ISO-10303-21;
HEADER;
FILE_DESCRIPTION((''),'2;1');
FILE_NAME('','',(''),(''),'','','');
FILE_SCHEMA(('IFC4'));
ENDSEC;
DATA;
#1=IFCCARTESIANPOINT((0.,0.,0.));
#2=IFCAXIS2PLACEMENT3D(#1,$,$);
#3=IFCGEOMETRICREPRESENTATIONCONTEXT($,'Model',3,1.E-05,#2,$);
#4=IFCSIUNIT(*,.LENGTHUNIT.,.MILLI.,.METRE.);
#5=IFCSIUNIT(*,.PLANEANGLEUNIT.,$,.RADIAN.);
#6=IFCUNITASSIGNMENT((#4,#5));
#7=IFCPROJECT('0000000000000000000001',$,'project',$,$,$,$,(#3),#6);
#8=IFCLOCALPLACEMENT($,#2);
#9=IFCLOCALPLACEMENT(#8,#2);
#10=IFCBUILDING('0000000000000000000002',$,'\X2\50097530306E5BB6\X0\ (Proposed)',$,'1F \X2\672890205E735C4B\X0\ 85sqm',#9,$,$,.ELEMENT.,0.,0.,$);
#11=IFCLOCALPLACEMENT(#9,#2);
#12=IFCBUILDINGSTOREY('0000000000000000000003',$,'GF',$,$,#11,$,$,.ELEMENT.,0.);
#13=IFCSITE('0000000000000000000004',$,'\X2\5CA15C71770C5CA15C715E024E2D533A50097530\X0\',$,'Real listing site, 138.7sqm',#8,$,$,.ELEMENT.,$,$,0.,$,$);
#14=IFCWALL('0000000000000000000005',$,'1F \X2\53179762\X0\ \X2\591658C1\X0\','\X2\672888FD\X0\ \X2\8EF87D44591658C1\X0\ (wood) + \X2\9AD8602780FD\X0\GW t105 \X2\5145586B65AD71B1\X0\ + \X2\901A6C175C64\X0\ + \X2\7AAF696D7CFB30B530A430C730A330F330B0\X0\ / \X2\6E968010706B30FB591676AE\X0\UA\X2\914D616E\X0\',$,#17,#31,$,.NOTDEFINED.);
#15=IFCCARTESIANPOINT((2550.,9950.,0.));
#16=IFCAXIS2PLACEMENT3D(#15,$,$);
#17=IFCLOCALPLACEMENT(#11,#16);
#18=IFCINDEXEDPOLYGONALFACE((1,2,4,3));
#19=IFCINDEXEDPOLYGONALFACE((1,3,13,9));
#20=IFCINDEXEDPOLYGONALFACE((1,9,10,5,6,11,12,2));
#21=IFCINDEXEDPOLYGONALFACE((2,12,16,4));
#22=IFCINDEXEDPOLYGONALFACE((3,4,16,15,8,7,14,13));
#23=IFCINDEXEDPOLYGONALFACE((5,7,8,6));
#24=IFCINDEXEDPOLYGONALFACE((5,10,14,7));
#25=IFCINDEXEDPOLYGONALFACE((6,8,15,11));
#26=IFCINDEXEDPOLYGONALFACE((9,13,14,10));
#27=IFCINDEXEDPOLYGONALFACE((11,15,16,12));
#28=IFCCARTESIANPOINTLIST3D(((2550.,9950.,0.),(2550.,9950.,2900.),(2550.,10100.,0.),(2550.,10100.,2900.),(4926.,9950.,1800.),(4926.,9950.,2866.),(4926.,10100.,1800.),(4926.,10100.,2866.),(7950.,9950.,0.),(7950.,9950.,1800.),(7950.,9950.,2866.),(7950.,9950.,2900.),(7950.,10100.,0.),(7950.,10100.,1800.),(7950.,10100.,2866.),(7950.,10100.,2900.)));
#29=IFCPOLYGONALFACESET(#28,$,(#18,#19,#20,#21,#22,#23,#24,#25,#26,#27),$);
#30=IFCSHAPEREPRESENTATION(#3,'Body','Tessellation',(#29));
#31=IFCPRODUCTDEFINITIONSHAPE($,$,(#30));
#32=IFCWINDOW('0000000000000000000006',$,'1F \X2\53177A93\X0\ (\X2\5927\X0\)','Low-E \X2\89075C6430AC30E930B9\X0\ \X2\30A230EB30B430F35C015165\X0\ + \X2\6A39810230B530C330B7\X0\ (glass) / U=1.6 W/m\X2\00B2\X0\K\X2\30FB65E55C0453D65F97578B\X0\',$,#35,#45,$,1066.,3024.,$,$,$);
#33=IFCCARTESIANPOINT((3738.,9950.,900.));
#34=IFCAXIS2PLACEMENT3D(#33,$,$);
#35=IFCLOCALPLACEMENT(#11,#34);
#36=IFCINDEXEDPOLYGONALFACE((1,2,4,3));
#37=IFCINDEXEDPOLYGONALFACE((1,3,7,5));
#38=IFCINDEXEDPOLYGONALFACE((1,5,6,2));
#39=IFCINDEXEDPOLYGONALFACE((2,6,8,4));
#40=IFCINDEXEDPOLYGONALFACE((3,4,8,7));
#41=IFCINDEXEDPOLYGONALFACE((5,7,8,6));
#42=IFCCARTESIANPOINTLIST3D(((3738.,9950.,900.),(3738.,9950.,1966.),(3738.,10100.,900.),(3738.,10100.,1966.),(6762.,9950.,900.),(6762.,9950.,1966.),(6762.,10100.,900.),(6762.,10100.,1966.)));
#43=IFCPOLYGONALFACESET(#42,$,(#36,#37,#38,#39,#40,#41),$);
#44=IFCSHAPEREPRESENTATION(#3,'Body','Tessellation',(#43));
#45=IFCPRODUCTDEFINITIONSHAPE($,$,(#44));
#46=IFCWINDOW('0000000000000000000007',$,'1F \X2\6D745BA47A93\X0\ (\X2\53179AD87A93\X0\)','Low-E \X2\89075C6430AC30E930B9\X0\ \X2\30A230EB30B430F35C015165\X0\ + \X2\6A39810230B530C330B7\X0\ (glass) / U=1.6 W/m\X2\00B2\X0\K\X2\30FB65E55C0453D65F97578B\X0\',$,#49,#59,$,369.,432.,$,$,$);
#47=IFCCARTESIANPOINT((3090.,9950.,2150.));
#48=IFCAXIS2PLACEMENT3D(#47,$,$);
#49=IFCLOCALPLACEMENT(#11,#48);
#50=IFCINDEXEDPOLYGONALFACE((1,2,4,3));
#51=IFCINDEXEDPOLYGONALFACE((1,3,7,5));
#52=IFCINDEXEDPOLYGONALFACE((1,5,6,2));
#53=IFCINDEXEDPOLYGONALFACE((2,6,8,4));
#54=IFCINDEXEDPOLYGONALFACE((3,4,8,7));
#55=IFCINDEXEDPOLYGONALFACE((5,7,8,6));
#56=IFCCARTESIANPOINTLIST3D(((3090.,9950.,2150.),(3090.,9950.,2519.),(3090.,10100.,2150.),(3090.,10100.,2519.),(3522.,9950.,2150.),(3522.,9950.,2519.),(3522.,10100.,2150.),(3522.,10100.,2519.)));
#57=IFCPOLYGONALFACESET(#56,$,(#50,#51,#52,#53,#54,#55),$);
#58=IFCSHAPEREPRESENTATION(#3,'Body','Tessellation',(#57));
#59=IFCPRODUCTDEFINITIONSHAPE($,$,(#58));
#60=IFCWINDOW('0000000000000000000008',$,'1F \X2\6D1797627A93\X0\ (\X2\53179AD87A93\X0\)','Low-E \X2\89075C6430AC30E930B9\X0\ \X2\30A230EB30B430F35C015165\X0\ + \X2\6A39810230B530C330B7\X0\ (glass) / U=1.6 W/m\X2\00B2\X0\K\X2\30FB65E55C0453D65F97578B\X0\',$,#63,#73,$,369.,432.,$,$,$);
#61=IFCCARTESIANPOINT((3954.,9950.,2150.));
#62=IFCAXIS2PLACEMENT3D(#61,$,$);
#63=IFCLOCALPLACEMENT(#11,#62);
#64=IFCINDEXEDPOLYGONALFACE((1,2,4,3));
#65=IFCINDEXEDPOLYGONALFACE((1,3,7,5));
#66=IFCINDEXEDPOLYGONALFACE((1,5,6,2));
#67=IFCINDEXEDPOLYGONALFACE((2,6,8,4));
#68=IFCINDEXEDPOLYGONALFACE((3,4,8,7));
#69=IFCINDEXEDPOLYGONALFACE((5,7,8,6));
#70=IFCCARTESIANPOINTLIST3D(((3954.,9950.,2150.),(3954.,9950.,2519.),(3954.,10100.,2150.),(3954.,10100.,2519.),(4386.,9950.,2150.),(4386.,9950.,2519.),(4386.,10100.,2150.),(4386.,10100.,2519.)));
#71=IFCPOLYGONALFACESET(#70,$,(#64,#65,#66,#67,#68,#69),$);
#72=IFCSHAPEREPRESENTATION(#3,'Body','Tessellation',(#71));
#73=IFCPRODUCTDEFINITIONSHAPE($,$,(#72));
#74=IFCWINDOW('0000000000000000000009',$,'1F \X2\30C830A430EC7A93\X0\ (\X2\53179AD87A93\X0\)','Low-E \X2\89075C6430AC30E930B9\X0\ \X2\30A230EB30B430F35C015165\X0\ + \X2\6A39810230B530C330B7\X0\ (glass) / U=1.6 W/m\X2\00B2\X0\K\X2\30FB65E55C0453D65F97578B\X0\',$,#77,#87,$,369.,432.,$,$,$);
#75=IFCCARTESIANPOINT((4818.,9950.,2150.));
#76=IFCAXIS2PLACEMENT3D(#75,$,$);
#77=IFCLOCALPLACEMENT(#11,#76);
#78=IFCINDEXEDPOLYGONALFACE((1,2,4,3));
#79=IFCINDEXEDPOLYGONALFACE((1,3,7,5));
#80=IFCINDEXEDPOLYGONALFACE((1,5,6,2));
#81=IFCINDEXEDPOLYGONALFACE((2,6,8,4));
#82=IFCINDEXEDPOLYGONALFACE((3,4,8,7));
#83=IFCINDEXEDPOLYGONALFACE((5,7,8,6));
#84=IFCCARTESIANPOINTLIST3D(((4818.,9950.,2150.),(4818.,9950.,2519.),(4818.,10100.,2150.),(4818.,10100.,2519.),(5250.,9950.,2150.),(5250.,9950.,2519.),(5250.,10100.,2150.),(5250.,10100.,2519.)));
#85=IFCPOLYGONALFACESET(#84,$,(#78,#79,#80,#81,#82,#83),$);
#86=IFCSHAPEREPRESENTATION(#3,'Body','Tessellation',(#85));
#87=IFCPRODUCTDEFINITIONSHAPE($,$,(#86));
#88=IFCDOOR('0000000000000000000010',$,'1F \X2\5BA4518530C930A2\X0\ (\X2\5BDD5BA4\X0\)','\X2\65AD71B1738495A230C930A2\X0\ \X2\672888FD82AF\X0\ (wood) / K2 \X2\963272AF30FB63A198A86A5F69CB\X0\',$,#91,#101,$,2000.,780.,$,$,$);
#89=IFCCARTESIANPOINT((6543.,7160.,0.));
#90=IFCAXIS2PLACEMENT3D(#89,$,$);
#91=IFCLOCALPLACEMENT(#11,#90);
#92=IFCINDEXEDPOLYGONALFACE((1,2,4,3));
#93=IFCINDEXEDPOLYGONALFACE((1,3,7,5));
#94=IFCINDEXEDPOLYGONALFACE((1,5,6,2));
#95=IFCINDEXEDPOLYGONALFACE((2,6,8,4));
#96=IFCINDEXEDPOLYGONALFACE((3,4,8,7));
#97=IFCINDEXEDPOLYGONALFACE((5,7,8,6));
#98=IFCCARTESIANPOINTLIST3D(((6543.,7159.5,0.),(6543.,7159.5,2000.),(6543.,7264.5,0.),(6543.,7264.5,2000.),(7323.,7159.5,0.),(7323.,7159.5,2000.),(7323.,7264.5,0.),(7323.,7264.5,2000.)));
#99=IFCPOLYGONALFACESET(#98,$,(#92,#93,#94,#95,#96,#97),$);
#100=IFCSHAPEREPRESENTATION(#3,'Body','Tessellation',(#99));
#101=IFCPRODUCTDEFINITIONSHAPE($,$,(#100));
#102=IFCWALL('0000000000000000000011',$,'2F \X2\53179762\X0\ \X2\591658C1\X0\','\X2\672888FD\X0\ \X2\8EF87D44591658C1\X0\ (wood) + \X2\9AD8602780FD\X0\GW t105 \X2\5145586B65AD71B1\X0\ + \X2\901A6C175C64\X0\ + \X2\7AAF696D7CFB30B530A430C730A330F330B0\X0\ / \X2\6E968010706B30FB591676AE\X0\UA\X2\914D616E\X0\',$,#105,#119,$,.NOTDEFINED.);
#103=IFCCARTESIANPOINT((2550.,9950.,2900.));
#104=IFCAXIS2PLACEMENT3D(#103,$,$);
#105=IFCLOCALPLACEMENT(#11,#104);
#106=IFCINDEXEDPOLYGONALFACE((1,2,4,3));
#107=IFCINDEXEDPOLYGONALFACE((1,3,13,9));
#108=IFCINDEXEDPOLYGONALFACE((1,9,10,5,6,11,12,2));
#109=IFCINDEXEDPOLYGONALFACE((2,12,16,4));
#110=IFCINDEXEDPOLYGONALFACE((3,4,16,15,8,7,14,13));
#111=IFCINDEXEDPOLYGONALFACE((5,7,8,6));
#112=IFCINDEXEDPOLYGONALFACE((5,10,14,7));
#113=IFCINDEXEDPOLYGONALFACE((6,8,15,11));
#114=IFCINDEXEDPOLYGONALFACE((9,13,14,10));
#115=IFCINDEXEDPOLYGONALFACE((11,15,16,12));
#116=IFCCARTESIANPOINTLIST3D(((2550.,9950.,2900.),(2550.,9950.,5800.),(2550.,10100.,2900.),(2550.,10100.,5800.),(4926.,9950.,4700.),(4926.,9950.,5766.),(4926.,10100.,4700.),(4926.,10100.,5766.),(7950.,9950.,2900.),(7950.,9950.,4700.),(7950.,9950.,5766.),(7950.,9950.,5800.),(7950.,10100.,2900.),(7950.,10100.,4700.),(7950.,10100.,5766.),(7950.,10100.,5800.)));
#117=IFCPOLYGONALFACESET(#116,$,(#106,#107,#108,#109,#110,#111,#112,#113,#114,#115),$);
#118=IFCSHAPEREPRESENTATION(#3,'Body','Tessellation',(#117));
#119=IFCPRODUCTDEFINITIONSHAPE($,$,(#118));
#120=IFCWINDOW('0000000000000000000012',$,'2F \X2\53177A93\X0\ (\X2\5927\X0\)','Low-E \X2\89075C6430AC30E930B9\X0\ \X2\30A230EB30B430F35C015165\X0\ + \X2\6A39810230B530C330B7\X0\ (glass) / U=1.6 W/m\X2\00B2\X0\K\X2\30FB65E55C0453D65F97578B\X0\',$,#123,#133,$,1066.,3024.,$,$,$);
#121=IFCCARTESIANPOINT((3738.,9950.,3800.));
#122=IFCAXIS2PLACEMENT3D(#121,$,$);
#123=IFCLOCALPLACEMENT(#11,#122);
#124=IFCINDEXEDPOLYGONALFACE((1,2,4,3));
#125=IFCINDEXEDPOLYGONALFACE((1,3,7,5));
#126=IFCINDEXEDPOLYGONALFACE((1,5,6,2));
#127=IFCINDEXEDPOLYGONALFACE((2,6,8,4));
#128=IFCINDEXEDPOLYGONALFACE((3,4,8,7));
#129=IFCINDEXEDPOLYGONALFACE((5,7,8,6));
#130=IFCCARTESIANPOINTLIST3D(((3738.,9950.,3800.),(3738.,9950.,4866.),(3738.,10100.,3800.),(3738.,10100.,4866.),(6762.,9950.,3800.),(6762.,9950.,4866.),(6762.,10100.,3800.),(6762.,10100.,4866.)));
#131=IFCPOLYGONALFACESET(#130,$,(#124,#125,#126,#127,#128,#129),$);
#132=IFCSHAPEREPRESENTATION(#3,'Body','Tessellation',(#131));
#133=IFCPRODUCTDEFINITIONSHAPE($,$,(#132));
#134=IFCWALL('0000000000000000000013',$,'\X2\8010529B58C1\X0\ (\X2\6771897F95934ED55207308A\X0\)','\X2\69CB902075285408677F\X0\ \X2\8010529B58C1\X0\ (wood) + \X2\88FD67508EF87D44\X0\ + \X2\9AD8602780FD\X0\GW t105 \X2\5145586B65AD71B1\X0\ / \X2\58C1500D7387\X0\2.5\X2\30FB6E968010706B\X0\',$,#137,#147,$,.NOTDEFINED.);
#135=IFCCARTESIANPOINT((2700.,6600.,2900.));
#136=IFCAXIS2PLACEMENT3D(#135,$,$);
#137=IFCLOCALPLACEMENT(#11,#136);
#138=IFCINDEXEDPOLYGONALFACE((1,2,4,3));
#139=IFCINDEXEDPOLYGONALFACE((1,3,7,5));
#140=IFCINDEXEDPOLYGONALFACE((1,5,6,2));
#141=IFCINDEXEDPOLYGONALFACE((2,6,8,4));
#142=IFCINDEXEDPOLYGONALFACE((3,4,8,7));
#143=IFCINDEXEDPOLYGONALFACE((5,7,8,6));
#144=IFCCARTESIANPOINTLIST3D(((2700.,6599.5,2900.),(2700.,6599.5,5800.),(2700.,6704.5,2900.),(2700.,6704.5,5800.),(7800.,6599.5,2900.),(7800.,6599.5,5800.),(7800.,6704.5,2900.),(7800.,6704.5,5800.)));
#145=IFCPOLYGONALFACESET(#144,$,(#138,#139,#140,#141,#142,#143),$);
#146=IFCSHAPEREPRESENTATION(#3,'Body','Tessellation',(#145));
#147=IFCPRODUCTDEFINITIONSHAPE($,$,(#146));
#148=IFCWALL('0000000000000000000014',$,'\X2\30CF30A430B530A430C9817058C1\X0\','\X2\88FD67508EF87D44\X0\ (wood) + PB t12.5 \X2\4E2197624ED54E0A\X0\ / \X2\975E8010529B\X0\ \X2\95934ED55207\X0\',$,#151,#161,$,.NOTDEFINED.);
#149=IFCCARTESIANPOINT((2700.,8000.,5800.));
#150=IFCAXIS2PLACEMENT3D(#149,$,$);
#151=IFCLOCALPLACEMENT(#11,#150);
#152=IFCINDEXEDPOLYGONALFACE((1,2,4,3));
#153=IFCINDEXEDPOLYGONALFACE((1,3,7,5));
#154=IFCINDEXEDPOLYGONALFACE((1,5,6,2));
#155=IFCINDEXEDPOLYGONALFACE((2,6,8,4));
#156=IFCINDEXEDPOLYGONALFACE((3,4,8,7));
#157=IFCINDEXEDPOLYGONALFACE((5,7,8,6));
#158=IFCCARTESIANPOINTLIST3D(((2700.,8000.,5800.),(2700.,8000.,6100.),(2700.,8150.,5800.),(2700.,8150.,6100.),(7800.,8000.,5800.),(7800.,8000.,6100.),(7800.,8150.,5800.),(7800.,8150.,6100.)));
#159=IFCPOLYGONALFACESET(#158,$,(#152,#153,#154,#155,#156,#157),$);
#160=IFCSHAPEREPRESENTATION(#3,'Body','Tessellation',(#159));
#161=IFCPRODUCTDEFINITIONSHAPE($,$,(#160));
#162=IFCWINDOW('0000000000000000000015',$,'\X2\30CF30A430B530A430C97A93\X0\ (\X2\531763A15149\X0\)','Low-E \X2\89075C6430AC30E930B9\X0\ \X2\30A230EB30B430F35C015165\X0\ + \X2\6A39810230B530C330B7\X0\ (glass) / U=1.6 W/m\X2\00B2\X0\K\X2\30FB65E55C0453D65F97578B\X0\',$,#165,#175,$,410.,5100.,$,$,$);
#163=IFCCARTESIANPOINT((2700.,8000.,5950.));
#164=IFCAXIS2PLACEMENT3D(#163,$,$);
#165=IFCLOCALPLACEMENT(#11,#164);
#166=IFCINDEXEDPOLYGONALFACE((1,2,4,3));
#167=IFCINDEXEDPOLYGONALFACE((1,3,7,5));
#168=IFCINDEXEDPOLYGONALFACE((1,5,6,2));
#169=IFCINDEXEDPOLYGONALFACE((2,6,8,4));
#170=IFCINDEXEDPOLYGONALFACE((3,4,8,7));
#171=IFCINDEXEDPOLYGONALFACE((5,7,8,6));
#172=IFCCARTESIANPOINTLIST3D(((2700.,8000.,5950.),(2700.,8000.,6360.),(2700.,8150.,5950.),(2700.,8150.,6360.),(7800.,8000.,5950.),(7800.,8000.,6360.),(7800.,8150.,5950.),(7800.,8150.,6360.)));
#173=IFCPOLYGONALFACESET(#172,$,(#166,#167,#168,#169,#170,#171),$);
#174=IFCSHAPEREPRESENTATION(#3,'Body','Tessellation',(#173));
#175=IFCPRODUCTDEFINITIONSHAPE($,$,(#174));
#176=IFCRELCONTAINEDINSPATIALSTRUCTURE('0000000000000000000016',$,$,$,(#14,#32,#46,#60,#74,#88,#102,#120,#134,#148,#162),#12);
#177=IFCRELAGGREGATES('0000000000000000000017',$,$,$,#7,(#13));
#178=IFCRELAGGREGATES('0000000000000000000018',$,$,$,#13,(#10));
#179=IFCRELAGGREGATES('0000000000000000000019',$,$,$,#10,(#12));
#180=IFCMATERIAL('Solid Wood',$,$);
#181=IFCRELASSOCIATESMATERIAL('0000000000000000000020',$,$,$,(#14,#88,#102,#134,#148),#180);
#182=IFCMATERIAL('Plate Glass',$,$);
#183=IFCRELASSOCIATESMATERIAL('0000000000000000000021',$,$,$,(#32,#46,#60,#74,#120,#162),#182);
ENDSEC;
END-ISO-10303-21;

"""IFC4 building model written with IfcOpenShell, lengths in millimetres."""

from ifc_helpers import new_model, si_unit, frame, frame_2d, origin, place, context, project, spatial, rectangle, extrude, material, element, fill, save


model = new_model("IFC4")

# Units and contexts
model_context = context("Model", 3, precision=1e-05, world=origin())
ifc_project = project(units=[si_unit("LENGTHUNIT", "METRE", prefix="MILLI"), si_unit("PLANEANGLEUNIT", "RADIAN")], contexts=[model_context])

# Site, building, storey
site_placement = place(None, origin())
site = spatial("IfcSite", under=ifc_project, at=site_placement, Name="岡山県岡山市中区倉田", ObjectType="Real listing site, 138.7sqm", CompositionType="ELEMENT", RefElevation=0.0)
building_placement = place(site_placement, origin())
building = spatial("IfcBuilding", under=site, at=building_placement, Name="倉田の家 (Proposed)", ObjectType="1F 木造平屋 85sqm", CompositionType="ELEMENT", ElevationOfRefHeight=0.0, ElevationOfTerrain=0.0)
storey_placement = place(building_placement, origin())
storey = spatial("IfcBuildingStorey", under=building, at=storey_placement, Name="GF", CompositionType="ELEMENT", Elevation=0.0)

# Wall, openings, windows
ifc_material_1 = material(Name="Solid Wood")
wall_1_placement = place(storey_placement, frame((2550.0, 9950.0, 0.0)))
wall_1 = element("IfcWall", 1, at=wall_1_placement, inside=storey, material=ifc_material_1, Name="1F 北面 外壁", Description="木製 軸組外壁 (wood) + 高性能GW t105 充填断熱 + 通気層 + 窯業系サイディング / 準耐火・外皮UA配慮", PredefinedType="NOTDEFINED", context=model_context, shape_type="SweptSolid", body=[
    extrude(rectangle(XDim=5400.0, YDim=150.0, at=frame_2d((2700.0, 75.0))), frame((2550.0, 9950.0, 0.0)), (0.0, 0.0, 1.0), 2900.0),
])
opening_1_placement = place(storey_placement, frame((3738.0, 9950.0, 900.0)))
opening_1 = element("IfcOpeningElement", 2, at=opening_1_placement, cuts=wall_1, PredefinedType="NOTDEFINED", context=model_context, shape_type="SweptSolid", body=[
    extrude(rectangle(XDim=3024.0, YDim=150.0, at=frame_2d((1512.0, 75.0))), frame((3738.0, 9950.0, 900.0)), (0.0, 0.0, 1.0), 1066.0),
])
opening_2_placement = place(storey_placement, frame((3090.0, 9950.0, 2150.0)))
opening_2 = element("IfcOpeningElement", 3, at=opening_2_placement, cuts=wall_1, PredefinedType="NOTDEFINED", context=model_context, shape_type="SweptSolid", body=[
    extrude(rectangle(XDim=432.0, YDim=150.0, at=frame_2d((216.0, 75.0))), frame((3090.0, 9950.0, 2150.0)), (0.0, 0.0, 1.0), 369.0),
])
opening_3_placement = place(storey_placement, frame((3954.0, 9950.0, 2150.0)))
opening_3 = element("IfcOpeningElement", 4, at=opening_3_placement, cuts=wall_1, PredefinedType="NOTDEFINED", context=model_context, shape_type="SweptSolid", body=[
    extrude(rectangle(XDim=432.0, YDim=150.0, at=frame_2d((216.0, 75.0))), frame((3954.0, 9950.0, 2150.0)), (0.0, 0.0, 1.0), 369.0),
])
opening_4_placement = place(storey_placement, frame((4818.0, 9950.0, 2150.0)))
opening_4 = element("IfcOpeningElement", 5, at=opening_4_placement, cuts=wall_1, PredefinedType="NOTDEFINED", context=model_context, shape_type="SweptSolid", body=[
    extrude(rectangle(XDim=432.0, YDim=150.0, at=frame_2d((216.0, 75.0))), frame((4818.0, 9950.0, 2150.0)), (0.0, 0.0, 1.0), 369.0),
])
ifc_material_2 = material(Name="Plate Glass")
window_1_placement = place(storey_placement, frame((3738.0, 9950.0, 900.0)))
window_1 = element("IfcWindow", 6, at=window_1_placement, inside=storey, material=ifc_material_2, Name="1F 北窓 (大)", Description="Low-E 複層ガラス アルゴン封入 + 樹脂サッシ (glass) / U=1.6 W/m²K・日射取得型", OverallHeight=1066.0, OverallWidth=3024.0, context=model_context, shape_type="SweptSolid", body=[
    extrude(rectangle(XDim=3024.0, YDim=150.0, at=frame_2d((1512.0, 75.0))), frame((3738.0, 9950.0, 900.0)), (0.0, 0.0, 1.0), 1066.0),
])
fill(opening_1, window_1)
window_2_placement = place(storey_placement, frame((3090.0, 9950.0, 2150.0)))
window_2 = element("IfcWindow", 7, at=window_2_placement, inside=storey, material=ifc_material_2, Name="1F 浴室窓 (北高窓)", Description="Low-E 複層ガラス アルゴン封入 + 樹脂サッシ (glass) / U=1.6 W/m²K・日射取得型", OverallHeight=369.0, OverallWidth=432.0, context=model_context, shape_type="SweptSolid", body=[
    extrude(rectangle(XDim=432.0, YDim=150.0, at=frame_2d((216.0, 75.0))), frame((3090.0, 9950.0, 2150.0)), (0.0, 0.0, 1.0), 369.0),
])
fill(opening_2, window_2)
window_3_placement = place(storey_placement, frame((3954.0, 9950.0, 2150.0)))
window_3 = element("IfcWindow", 8, at=window_3_placement, inside=storey, material=ifc_material_2, Name="1F 洗面窓 (北高窓)", Description="Low-E 複層ガラス アルゴン封入 + 樹脂サッシ (glass) / U=1.6 W/m²K・日射取得型", OverallHeight=369.0, OverallWidth=432.0, context=model_context, shape_type="SweptSolid", body=[
    extrude(rectangle(XDim=432.0, YDim=150.0, at=frame_2d((216.0, 75.0))), frame((3954.0, 9950.0, 2150.0)), (0.0, 0.0, 1.0), 369.0),
])
fill(opening_3, window_3)
window_4_placement = place(storey_placement, frame((4818.0, 9950.0, 2150.0)))
window_4 = element("IfcWindow", 9, at=window_4_placement, inside=storey, material=ifc_material_2, Name="1F トイレ窓 (北高窓)", Description="Low-E 複層ガラス アルゴン封入 + 樹脂サッシ (glass) / U=1.6 W/m²K・日射取得型", OverallHeight=369.0, OverallWidth=432.0, context=model_context, shape_type="SweptSolid", body=[
    extrude(rectangle(XDim=432.0, YDim=150.0, at=frame_2d((216.0, 75.0))), frame((4818.0, 9950.0, 2150.0)), (0.0, 0.0, 1.0), 369.0),
])
fill(opening_4, window_4)

# Door
door_1_placement = place(storey_placement, frame((6543.0, 7160.0, 0.0)))
element("IfcDoor", 10, at=door_1_placement, inside=storey, material=ifc_material_1, Name="1F 室内ドア (寝室)", Description="断熱玄関ドア 木製芯 (wood) / K2 防犯・採風機構", OverallHeight=2000.0, OverallWidth=780.0, context=model_context, shape_type="SweptSolid", body=[
    extrude(rectangle(XDim=780.0, YDim=105.0, at=frame_2d((390.0, 52.0))), frame((6543.0, 7160.0, 0.0)), (0.0, 0.0, 1.0), 2000.0),
])

# Wall, opening, window
wall_2_placement = place(storey_placement, frame((2550.0, 9950.0, 2900.0)))
wall_2 = element("IfcWall", 11, at=wall_2_placement, inside=storey, material=ifc_material_1, Name="2F 北面 外壁", Description="木製 軸組外壁 (wood) + 高性能GW t105 充填断熱 + 通気層 + 窯業系サイディング / 準耐火・外皮UA配慮", PredefinedType="NOTDEFINED", context=model_context, shape_type="SweptSolid", body=[
    extrude(rectangle(XDim=5400.0, YDim=150.0, at=frame_2d((2700.0, 75.0))), frame((2550.0, 9950.0, 2900.0)), (0.0, 0.0, 1.0), 2900.0),
])
opening_5_placement = place(storey_placement, frame((3738.0, 9950.0, 3800.0)))
opening_5 = element("IfcOpeningElement", 12, at=opening_5_placement, cuts=wall_2, PredefinedType="NOTDEFINED", context=model_context, shape_type="SweptSolid", body=[
    extrude(rectangle(XDim=3024.0, YDim=150.0, at=frame_2d((1512.0, 75.0))), frame((3738.0, 9950.0, 3800.0)), (0.0, 0.0, 1.0), 1066.0),
])
window_5_placement = place(storey_placement, frame((3738.0, 9950.0, 3800.0)))
window_5 = element("IfcWindow", 13, at=window_5_placement, inside=storey, material=ifc_material_2, Name="2F 北窓 (大)", Description="Low-E 複層ガラス アルゴン封入 + 樹脂サッシ (glass) / U=1.6 W/m²K・日射取得型", OverallHeight=1066.0, OverallWidth=3024.0, context=model_context, shape_type="SweptSolid", body=[
    extrude(rectangle(XDim=3024.0, YDim=150.0, at=frame_2d((1512.0, 75.0))), frame((3738.0, 9950.0, 3800.0)), (0.0, 0.0, 1.0), 1066.0),
])
fill(opening_5, window_5)

# Wall
wall_3_placement = place(storey_placement, frame((2700.0, 6600.0, 2900.0)))
element("IfcWall", 14, at=wall_3_placement, inside=storey, material=ifc_material_1, Name="耐力壁 (東西間仕切り)", Description="構造用合板 耐力壁 (wood) + 製材軸組 + 高性能GW t105 充填断熱 / 壁倍率2.5・準耐火", PredefinedType="NOTDEFINED", context=model_context, shape_type="SweptSolid", body=[
    extrude(rectangle(XDim=5100.0, YDim=105.0, at=frame_2d((2550.0, 52.0))), frame((2700.0, 6600.0, 2900.0)), (0.0, 0.0, 1.0), 2900.0),
])

# Wall, opening, window
wall_4_placement = place(storey_placement, frame((2700.0, 8000.0, 5800.0)))
wall_4 = element("IfcWall", 15, at=wall_4_placement, inside=storey, material=ifc_material_1, Name="ハイサイド腰壁", Description="製材軸組 (wood) + PB t12.5 両面仕上 / 非耐力 間仕切", PredefinedType="NOTDEFINED", context=model_context, shape_type="SweptSolid", body=[
    extrude(rectangle(XDim=5100.0, YDim=150.0, at=frame_2d((2550.0, 75.0))), frame((2700.0, 8000.0, 5800.0)), (0.0, 0.0, 1.0), 700.0),
])
opening_6_placement = place(storey_placement, frame((2700.0, 8000.0, 5950.0)))
opening_6 = element("IfcOpeningElement", 16, at=opening_6_placement, cuts=wall_4, PredefinedType="NOTDEFINED", context=model_context, shape_type="SweptSolid", body=[
    extrude(rectangle(XDim=5100.0, YDim=150.0, at=frame_2d((2550.0, 75.0))), frame((2700.0, 8000.0, 5950.0)), (0.0, 0.0, 1.0), 410.0),
])
window_6_placement = place(storey_placement, frame((2700.0, 8000.0, 5950.0)))
window_6 = element("IfcWindow", 17, at=window_6_placement, inside=storey, material=ifc_material_2, Name="ハイサイド窓 (北採光)", Description="Low-E 複層ガラス アルゴン封入 + 樹脂サッシ (glass) / U=1.6 W/m²K・日射取得型", OverallHeight=410.0, OverallWidth=5100.0, context=model_context, shape_type="SweptSolid", body=[
    extrude(rectangle(XDim=5100.0, YDim=150.0, at=frame_2d((2550.0, 75.0))), frame((2700.0, 8000.0, 5950.0)), (0.0, 0.0, 1.0), 410.0),
])
fill(opening_6, window_6)

save(model, "model.ifc")
